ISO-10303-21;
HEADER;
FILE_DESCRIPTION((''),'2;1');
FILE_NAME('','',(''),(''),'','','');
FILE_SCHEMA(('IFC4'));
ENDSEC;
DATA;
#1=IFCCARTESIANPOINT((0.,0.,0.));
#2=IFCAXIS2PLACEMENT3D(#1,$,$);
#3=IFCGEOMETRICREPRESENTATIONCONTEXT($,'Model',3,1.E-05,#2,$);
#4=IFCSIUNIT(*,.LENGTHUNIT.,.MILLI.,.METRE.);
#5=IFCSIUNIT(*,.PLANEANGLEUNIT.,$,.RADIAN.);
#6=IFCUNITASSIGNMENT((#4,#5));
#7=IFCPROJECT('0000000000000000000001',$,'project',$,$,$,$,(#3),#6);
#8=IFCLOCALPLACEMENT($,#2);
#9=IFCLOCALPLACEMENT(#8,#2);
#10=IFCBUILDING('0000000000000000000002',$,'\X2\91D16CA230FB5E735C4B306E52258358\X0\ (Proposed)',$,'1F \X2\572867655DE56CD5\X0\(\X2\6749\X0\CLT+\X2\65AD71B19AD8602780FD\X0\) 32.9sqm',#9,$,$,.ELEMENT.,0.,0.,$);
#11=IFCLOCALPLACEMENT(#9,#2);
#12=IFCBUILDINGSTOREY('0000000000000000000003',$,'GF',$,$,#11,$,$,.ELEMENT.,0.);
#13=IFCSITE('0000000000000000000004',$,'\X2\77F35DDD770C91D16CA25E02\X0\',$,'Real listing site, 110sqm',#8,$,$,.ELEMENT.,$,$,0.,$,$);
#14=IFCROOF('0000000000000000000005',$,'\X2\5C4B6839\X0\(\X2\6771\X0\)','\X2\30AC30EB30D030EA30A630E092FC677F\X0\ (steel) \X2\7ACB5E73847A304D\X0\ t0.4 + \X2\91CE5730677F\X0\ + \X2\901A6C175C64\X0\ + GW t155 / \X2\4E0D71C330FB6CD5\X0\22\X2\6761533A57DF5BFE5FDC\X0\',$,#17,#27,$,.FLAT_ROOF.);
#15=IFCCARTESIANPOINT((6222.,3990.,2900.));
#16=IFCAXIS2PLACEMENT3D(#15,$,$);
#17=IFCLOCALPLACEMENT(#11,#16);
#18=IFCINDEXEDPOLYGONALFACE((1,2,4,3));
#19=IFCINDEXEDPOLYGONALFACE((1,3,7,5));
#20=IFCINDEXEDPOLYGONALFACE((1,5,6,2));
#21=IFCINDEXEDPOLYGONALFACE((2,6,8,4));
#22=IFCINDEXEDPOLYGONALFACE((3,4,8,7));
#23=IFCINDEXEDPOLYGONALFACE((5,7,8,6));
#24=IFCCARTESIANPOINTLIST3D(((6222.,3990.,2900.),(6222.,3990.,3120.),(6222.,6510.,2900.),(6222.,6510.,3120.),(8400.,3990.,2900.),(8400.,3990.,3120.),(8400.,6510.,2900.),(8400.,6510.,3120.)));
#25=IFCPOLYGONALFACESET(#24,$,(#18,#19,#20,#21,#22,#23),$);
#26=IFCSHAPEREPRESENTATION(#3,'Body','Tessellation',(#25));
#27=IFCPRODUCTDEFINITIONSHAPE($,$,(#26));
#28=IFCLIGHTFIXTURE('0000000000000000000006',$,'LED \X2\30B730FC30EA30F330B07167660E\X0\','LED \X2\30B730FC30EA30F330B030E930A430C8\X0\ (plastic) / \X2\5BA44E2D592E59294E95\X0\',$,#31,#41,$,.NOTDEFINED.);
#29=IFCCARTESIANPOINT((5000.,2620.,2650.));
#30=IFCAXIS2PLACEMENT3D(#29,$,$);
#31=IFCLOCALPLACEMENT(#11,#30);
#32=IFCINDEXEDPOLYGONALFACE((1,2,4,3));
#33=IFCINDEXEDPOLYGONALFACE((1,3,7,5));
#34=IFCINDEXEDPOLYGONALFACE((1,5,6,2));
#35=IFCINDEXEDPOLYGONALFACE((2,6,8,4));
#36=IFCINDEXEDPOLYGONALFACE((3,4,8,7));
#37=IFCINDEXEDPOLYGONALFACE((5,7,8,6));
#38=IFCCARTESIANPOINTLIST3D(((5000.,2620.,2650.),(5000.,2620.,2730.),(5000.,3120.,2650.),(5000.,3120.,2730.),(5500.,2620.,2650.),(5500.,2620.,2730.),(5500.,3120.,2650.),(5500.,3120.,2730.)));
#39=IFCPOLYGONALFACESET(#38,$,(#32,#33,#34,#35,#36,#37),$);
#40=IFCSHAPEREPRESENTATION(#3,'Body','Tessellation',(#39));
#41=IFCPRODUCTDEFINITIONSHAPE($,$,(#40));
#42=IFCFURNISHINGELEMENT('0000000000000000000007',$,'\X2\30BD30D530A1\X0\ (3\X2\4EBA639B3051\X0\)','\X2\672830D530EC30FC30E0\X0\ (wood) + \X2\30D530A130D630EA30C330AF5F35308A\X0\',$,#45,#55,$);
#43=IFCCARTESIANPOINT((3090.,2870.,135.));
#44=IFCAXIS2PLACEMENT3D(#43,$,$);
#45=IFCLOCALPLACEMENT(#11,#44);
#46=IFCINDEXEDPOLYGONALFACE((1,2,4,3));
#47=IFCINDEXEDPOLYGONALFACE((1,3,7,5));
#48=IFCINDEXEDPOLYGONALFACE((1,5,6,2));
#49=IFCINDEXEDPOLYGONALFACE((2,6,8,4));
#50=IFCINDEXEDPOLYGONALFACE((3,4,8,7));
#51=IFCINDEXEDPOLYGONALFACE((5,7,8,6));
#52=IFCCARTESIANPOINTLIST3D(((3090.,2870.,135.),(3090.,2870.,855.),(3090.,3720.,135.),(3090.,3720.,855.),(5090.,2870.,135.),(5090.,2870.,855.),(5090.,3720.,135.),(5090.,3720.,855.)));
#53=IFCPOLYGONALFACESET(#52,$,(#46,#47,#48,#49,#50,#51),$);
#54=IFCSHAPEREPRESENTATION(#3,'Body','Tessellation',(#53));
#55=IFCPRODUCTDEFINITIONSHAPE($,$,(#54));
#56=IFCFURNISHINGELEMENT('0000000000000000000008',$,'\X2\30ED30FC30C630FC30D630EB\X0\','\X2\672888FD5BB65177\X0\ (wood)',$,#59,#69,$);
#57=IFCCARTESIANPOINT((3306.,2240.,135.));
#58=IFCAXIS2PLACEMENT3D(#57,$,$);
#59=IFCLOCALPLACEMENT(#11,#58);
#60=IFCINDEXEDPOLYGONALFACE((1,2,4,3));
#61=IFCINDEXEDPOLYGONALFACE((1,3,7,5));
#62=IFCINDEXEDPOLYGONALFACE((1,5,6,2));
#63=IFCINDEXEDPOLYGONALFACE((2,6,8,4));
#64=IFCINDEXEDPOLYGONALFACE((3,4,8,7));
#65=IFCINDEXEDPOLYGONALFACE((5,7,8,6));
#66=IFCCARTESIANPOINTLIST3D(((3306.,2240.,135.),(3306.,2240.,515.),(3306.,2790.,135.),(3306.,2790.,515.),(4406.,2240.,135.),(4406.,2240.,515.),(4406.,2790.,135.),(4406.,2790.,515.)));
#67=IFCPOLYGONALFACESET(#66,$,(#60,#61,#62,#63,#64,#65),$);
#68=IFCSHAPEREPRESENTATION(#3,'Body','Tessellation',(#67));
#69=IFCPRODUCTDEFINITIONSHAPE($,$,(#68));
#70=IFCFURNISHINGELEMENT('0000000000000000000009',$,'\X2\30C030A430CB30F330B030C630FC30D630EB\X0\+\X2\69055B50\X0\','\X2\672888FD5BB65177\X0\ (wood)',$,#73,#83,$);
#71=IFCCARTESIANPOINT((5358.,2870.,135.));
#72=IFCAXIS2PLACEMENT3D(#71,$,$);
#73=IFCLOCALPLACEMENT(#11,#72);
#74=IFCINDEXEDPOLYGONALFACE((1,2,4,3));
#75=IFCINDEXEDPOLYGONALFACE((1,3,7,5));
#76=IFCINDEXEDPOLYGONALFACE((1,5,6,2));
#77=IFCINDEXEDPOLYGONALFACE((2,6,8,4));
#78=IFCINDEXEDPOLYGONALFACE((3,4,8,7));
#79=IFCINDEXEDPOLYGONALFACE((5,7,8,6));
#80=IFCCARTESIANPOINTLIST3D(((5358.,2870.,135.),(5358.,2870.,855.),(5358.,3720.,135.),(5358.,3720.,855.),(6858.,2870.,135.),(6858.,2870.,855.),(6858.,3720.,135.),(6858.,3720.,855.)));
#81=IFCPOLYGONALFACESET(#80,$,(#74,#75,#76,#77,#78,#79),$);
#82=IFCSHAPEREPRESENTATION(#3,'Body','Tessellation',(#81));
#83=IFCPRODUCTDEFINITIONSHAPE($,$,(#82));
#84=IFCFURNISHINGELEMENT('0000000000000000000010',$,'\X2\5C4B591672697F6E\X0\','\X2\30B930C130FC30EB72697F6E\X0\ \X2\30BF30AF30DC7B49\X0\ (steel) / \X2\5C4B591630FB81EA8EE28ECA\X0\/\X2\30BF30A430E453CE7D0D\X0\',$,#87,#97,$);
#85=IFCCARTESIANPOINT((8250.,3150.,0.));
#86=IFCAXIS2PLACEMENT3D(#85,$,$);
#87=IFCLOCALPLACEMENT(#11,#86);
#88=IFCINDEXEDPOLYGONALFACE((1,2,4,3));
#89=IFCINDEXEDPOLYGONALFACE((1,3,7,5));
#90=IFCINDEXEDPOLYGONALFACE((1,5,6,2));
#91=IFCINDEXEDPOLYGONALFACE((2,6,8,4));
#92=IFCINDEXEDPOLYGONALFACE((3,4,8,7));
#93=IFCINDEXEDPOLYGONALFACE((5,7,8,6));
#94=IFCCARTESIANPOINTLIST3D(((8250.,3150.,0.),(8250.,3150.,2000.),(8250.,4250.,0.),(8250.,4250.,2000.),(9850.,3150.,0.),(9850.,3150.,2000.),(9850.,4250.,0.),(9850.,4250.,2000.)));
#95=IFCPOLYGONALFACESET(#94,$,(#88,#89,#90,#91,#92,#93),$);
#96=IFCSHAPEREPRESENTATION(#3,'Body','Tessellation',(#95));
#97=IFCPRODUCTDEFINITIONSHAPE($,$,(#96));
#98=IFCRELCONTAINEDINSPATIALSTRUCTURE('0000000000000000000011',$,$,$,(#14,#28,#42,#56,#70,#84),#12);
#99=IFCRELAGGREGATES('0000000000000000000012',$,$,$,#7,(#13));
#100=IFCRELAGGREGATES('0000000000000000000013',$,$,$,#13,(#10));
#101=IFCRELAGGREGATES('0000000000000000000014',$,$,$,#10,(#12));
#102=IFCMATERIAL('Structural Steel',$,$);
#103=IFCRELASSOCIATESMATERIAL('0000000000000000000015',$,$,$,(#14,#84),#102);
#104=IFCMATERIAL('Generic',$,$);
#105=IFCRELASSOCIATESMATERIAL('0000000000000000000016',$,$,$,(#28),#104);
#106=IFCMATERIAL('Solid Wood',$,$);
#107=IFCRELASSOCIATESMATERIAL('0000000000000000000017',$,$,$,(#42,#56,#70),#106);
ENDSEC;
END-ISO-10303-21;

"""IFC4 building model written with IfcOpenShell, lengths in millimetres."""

from ifc_helpers import new_model, si_unit, frame, frame_2d, origin, place, context, project, spatial, rectangle, extrude, material, element, save


model = new_model("IFC4")

# Units and contexts
model_context = context("Model", 3, precision=1e-05, world=origin())
ifc_project = project(units=[si_unit("LENGTHUNIT", "METRE", prefix="MILLI"), si_unit("PLANEANGLEUNIT", "RADIAN")], contexts=[model_context])

# Site, building, storey
site_placement = place(None, origin())
site = spatial("IfcSite", under=ifc_project, at=site_placement, Name="石川県金沢市", ObjectType="Real listing site, 110sqm", CompositionType="ELEMENT", RefElevation=0.0)
building_placement = place(site_placement, origin())
building = spatial("IfcBuilding", under=site, at=building_placement, Name="金沢・平屋の別荘 (Proposed)", ObjectType="1F 在来工法(杉CLT+断熱高性能) 32.9sqm", CompositionType="ELEMENT", ElevationOfRefHeight=0.0, ElevationOfTerrain=0.0)
storey_placement = place(building_placement, origin())
storey = spatial("IfcBuildingStorey", under=building, at=storey_placement, Name="GF", CompositionType="ELEMENT", Elevation=0.0)

# Shared definitions
ifc_material_1 = material(Name="Solid Wood")

# Roof
ifc_material_2 = material(Name="Structural Steel")
roof_1_placement = place(storey_placement, frame((6222.0, 3990.0, 2900.0)))
element("IfcRoof", 1, at=roof_1_placement, inside=storey, material=ifc_material_2, Name="屋根(東)", Description="ガルバリウム鋼板 (steel) 立平葺き t0.4 + 野地板 + 通気層 + GW t155 / 不燃・法22条区域対応", PredefinedType="FLAT_ROOF", context=model_context, shape_type="SweptSolid", body=[
    extrude(rectangle(XDim=2178.0, YDim=2520.0, at=frame_2d((1089.0, 1260.0))), frame((6222.0, 3990.0, 2900.0)), (0.0, 0.0, 1.0), 220.0),
])

# Light fixture
ifc_material_3 = material(Name="Generic")
light_fixture_placement = place(storey_placement, frame((5000.0, 2620.0, 2650.0)))
element("IfcLightFixture", 2, at=light_fixture_placement, inside=storey, material=ifc_material_3, Name="LED シーリング照明", Description="LED シーリングライト (plastic) / 室中央天井", PredefinedType="NOTDEFINED", context=model_context, shape_type="SweptSolid", body=[
    extrude(rectangle(XDim=500.0, YDim=500.0, at=frame_2d((250.0, 250.0))), frame((5000.0, 2620.0, 2650.0)), (0.0, 0.0, 1.0), 80.0),
])

# Furnishing elements
furnishing_1_placement = place(storey_placement, frame((3090.0, 2870.0, 135.0)))
element("IfcFurnishingElement", 3, at=furnishing_1_placement, inside=storey, material=ifc_material_1, Name="ソファ (3人掛け)", Description="木フレーム (wood) + ファブリック張り", context=model_context, shape_type="SweptSolid", body=[
    extrude(rectangle(XDim=2000.0, YDim=850.0, at=frame_2d((1000.0, 425.0))), frame((3090.0, 2870.0, 135.0)), (0.0, 0.0, 1.0), 720.0),
])
furnishing_2_placement = place(storey_placement, frame((3306.0, 2240.0, 135.0)))
element("IfcFurnishingElement", 4, at=furnishing_2_placement, inside=storey, material=ifc_material_1, Name="ローテーブル", Description="木製家具 (wood)", context=model_context, shape_type="SweptSolid", body=[
    extrude(rectangle(XDim=1100.0, YDim=550.0, at=frame_2d((550.0, 275.0))), frame((3306.0, 2240.0, 135.0)), (0.0, 0.0, 1.0), 380.0),
])
furnishing_3_placement = place(storey_placement, frame((5358.0, 2870.0, 135.0)))
element("IfcFurnishingElement", 5, at=furnishing_3_placement, inside=storey, material=ifc_material_1, Name="ダイニングテーブル+椅子", Description="木製家具 (wood)", context=model_context, shape_type="SweptSolid", body=[
    extrude(rectangle(XDim=1500.0, YDim=850.0, at=frame_2d((750.0, 425.0))), frame((5358.0, 2870.0, 135.0)), (0.0, 0.0, 1.0), 720.0),
])
furnishing_4_placement = place(storey_placement, frame((8250.0, 3150.0, 0.0)))
element("IfcFurnishingElement", 6, at=furnishing_4_placement, inside=storey, material=ifc_material_2, Name="屋外物置", Description="スチール物置 タクボ等 (steel) / 屋外・自転車/タイヤ収納", context=model_context, shape_type="SweptSolid", body=[
    extrude(rectangle(XDim=1600.0, YDim=1100.0, at=frame_2d((800.0, 550.0))), frame((8250.0, 3150.0, 0.0)), (0.0, 0.0, 1.0), 2000.0),
])

save(model, "model.ifc")
